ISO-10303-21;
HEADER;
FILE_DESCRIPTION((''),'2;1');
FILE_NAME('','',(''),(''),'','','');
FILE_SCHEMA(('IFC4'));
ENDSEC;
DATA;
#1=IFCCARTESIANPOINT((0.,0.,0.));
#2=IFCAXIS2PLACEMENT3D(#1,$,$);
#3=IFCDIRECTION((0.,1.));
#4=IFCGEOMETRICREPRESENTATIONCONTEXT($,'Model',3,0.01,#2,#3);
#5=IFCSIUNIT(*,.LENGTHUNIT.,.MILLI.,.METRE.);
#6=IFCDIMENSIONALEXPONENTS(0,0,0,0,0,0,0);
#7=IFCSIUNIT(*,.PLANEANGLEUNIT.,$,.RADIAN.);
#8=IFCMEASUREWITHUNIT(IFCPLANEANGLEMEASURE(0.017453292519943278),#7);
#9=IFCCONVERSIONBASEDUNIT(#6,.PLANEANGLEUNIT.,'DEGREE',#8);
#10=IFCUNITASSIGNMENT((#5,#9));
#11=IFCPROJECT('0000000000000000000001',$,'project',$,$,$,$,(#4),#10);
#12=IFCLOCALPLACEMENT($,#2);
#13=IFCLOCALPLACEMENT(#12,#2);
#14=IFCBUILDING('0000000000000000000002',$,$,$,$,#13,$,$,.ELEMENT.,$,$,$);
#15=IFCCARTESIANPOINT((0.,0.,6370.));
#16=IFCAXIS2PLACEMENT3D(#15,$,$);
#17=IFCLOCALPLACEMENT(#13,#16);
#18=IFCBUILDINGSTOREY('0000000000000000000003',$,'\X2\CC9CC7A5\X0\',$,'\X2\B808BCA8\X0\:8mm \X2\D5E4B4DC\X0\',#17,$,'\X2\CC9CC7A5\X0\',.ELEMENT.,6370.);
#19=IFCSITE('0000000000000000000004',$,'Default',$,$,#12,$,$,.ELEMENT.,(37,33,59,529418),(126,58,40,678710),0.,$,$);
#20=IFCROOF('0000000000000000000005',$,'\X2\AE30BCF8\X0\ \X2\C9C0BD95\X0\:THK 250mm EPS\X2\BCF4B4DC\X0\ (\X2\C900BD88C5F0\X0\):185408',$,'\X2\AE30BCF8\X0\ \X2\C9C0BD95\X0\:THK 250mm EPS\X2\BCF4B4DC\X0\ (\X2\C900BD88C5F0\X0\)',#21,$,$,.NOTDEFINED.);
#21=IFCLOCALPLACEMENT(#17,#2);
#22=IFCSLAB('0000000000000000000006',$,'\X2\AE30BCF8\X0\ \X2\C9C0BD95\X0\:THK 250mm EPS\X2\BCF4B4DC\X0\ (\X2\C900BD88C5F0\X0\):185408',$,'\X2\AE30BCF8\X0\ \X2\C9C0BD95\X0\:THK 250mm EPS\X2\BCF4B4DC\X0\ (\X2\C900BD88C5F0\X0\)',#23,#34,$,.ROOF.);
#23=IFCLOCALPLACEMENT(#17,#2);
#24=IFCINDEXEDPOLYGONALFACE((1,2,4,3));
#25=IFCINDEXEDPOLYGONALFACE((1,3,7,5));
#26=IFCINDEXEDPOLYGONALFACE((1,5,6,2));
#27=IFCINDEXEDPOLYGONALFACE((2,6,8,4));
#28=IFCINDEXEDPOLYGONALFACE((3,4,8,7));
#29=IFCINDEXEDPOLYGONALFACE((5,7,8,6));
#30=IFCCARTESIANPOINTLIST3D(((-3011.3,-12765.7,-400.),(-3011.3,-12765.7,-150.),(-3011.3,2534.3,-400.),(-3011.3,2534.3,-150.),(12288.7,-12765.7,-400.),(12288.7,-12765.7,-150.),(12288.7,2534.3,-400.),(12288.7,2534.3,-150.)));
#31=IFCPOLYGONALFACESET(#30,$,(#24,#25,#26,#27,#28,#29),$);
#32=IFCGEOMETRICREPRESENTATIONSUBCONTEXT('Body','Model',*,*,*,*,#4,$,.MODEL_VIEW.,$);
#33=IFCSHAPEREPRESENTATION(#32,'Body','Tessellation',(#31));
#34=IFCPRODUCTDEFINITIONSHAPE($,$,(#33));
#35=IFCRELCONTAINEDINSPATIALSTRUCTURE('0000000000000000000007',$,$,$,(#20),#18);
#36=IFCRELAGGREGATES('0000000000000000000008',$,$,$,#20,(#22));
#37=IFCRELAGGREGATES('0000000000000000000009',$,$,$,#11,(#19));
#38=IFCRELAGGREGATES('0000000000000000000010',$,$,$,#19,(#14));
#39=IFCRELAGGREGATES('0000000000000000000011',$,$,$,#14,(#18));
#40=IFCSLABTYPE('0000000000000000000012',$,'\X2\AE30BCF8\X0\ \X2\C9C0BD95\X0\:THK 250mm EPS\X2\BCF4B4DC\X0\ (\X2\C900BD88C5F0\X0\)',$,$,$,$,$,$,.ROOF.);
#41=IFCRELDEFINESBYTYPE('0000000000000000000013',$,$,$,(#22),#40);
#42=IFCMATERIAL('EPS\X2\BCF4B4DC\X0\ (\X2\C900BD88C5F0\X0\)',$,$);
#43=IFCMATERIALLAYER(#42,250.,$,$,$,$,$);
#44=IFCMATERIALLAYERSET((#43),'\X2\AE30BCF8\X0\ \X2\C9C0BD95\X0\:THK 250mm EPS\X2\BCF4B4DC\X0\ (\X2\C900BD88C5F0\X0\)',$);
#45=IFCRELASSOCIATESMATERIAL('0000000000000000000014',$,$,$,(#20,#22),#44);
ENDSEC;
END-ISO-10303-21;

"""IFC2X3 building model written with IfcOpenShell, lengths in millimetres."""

from ifc_helpers import new_model, entity, si_unit, converted_unit, direction, frame, frame_2d, origin, place, context, subcontext, project, spatial, rectangle, extrude, material, layer, layer_set, type_object, element, aggregate, save


model = new_model("IFC2X3")

# Units and contexts
model_context = context("Model", 3, precision=0.01, world=origin(), true_north=direction((0.0, 1.0)))
body_context = subcontext(model_context, "Body", "Model", "MODEL_VIEW")
ifc_project = project(units=[si_unit("LENGTHUNIT", "METRE", prefix="MILLI"), converted_unit("PLANEANGLEUNIT", "DEGREE", entity("IfcPlaneAngleMeasure", 0.017453292519943278), si_unit("PLANEANGLEUNIT", "RADIAN"), dimensions=[0, 0, 0, 0, 0, 0, 0])], contexts=[model_context])

# Site, building, storey
site_placement = place(None, origin())
site = spatial("IfcSite", under=ifc_project, at=site_placement, Name="Default", CompositionType="ELEMENT", RefLatitude=(37, 33, 59, 529418), RefLongitude=(126, 58, 40, 678710), RefElevation=0.0)
building_placement = place(site_placement, origin())
building = spatial("IfcBuilding", under=site, at=building_placement, CompositionType="ELEMENT")
storey_placement = place(building_placement, frame((0.0, 0.0, 6370.0)))
storey = spatial("IfcBuildingStorey", under=building, at=storey_placement, Name="천장", ObjectType="레벨:8mm 헤드", LongName="천장", CompositionType="ELEMENT", Elevation=6370.0)

# Roof, slab
ifc_material = material(Name="EPS보드 (준불연)")
ifc_layer = layer(ifc_material, 250.0)
ifc_layer_set = layer_set([ifc_layer], Name="기본 지붕:THK 250mm EPS보드 (준불연)")
roof_placement = place(storey_placement, frame((-3011.3, -12765.7, -400.0)))
roof = element("IfcRoof", 1, at=roof_placement, inside=storey, material=ifc_layer_set, Name="기본 지붕:THK 250mm EPS보드 (준불연):185408", ObjectType="기본 지붕:THK 250mm EPS보드 (준불연)", ShapeType="NOTDEFINED")
slab_type = type_object("IfcSlabType", Name="기본 지붕:THK 250mm EPS보드 (준불연)", PredefinedType="ROOF")
slab_placement = place(roof_placement, origin())
slab = element("IfcSlab", 2, at=slab_placement, type_object=slab_type, material=ifc_layer_set, Name="기본 지붕:THK 250mm EPS보드 (준불연):185408", ObjectType="기본 지붕:THK 250mm EPS보드 (준불연)", PredefinedType="ROOF", context=body_context, shape_type="SweptSolid", body=[
    extrude(rectangle(XDim=15300.0, YDim=15300.0, at=frame_2d((0.0, 0.0), x_axis=(0.0, 1.0))), frame((7650.0, 7650.0, 0.0)), (0.0, 0.0, 1.0), 250.0),
])
aggregate(roof, [slab])

save(model, "model.ifc")
